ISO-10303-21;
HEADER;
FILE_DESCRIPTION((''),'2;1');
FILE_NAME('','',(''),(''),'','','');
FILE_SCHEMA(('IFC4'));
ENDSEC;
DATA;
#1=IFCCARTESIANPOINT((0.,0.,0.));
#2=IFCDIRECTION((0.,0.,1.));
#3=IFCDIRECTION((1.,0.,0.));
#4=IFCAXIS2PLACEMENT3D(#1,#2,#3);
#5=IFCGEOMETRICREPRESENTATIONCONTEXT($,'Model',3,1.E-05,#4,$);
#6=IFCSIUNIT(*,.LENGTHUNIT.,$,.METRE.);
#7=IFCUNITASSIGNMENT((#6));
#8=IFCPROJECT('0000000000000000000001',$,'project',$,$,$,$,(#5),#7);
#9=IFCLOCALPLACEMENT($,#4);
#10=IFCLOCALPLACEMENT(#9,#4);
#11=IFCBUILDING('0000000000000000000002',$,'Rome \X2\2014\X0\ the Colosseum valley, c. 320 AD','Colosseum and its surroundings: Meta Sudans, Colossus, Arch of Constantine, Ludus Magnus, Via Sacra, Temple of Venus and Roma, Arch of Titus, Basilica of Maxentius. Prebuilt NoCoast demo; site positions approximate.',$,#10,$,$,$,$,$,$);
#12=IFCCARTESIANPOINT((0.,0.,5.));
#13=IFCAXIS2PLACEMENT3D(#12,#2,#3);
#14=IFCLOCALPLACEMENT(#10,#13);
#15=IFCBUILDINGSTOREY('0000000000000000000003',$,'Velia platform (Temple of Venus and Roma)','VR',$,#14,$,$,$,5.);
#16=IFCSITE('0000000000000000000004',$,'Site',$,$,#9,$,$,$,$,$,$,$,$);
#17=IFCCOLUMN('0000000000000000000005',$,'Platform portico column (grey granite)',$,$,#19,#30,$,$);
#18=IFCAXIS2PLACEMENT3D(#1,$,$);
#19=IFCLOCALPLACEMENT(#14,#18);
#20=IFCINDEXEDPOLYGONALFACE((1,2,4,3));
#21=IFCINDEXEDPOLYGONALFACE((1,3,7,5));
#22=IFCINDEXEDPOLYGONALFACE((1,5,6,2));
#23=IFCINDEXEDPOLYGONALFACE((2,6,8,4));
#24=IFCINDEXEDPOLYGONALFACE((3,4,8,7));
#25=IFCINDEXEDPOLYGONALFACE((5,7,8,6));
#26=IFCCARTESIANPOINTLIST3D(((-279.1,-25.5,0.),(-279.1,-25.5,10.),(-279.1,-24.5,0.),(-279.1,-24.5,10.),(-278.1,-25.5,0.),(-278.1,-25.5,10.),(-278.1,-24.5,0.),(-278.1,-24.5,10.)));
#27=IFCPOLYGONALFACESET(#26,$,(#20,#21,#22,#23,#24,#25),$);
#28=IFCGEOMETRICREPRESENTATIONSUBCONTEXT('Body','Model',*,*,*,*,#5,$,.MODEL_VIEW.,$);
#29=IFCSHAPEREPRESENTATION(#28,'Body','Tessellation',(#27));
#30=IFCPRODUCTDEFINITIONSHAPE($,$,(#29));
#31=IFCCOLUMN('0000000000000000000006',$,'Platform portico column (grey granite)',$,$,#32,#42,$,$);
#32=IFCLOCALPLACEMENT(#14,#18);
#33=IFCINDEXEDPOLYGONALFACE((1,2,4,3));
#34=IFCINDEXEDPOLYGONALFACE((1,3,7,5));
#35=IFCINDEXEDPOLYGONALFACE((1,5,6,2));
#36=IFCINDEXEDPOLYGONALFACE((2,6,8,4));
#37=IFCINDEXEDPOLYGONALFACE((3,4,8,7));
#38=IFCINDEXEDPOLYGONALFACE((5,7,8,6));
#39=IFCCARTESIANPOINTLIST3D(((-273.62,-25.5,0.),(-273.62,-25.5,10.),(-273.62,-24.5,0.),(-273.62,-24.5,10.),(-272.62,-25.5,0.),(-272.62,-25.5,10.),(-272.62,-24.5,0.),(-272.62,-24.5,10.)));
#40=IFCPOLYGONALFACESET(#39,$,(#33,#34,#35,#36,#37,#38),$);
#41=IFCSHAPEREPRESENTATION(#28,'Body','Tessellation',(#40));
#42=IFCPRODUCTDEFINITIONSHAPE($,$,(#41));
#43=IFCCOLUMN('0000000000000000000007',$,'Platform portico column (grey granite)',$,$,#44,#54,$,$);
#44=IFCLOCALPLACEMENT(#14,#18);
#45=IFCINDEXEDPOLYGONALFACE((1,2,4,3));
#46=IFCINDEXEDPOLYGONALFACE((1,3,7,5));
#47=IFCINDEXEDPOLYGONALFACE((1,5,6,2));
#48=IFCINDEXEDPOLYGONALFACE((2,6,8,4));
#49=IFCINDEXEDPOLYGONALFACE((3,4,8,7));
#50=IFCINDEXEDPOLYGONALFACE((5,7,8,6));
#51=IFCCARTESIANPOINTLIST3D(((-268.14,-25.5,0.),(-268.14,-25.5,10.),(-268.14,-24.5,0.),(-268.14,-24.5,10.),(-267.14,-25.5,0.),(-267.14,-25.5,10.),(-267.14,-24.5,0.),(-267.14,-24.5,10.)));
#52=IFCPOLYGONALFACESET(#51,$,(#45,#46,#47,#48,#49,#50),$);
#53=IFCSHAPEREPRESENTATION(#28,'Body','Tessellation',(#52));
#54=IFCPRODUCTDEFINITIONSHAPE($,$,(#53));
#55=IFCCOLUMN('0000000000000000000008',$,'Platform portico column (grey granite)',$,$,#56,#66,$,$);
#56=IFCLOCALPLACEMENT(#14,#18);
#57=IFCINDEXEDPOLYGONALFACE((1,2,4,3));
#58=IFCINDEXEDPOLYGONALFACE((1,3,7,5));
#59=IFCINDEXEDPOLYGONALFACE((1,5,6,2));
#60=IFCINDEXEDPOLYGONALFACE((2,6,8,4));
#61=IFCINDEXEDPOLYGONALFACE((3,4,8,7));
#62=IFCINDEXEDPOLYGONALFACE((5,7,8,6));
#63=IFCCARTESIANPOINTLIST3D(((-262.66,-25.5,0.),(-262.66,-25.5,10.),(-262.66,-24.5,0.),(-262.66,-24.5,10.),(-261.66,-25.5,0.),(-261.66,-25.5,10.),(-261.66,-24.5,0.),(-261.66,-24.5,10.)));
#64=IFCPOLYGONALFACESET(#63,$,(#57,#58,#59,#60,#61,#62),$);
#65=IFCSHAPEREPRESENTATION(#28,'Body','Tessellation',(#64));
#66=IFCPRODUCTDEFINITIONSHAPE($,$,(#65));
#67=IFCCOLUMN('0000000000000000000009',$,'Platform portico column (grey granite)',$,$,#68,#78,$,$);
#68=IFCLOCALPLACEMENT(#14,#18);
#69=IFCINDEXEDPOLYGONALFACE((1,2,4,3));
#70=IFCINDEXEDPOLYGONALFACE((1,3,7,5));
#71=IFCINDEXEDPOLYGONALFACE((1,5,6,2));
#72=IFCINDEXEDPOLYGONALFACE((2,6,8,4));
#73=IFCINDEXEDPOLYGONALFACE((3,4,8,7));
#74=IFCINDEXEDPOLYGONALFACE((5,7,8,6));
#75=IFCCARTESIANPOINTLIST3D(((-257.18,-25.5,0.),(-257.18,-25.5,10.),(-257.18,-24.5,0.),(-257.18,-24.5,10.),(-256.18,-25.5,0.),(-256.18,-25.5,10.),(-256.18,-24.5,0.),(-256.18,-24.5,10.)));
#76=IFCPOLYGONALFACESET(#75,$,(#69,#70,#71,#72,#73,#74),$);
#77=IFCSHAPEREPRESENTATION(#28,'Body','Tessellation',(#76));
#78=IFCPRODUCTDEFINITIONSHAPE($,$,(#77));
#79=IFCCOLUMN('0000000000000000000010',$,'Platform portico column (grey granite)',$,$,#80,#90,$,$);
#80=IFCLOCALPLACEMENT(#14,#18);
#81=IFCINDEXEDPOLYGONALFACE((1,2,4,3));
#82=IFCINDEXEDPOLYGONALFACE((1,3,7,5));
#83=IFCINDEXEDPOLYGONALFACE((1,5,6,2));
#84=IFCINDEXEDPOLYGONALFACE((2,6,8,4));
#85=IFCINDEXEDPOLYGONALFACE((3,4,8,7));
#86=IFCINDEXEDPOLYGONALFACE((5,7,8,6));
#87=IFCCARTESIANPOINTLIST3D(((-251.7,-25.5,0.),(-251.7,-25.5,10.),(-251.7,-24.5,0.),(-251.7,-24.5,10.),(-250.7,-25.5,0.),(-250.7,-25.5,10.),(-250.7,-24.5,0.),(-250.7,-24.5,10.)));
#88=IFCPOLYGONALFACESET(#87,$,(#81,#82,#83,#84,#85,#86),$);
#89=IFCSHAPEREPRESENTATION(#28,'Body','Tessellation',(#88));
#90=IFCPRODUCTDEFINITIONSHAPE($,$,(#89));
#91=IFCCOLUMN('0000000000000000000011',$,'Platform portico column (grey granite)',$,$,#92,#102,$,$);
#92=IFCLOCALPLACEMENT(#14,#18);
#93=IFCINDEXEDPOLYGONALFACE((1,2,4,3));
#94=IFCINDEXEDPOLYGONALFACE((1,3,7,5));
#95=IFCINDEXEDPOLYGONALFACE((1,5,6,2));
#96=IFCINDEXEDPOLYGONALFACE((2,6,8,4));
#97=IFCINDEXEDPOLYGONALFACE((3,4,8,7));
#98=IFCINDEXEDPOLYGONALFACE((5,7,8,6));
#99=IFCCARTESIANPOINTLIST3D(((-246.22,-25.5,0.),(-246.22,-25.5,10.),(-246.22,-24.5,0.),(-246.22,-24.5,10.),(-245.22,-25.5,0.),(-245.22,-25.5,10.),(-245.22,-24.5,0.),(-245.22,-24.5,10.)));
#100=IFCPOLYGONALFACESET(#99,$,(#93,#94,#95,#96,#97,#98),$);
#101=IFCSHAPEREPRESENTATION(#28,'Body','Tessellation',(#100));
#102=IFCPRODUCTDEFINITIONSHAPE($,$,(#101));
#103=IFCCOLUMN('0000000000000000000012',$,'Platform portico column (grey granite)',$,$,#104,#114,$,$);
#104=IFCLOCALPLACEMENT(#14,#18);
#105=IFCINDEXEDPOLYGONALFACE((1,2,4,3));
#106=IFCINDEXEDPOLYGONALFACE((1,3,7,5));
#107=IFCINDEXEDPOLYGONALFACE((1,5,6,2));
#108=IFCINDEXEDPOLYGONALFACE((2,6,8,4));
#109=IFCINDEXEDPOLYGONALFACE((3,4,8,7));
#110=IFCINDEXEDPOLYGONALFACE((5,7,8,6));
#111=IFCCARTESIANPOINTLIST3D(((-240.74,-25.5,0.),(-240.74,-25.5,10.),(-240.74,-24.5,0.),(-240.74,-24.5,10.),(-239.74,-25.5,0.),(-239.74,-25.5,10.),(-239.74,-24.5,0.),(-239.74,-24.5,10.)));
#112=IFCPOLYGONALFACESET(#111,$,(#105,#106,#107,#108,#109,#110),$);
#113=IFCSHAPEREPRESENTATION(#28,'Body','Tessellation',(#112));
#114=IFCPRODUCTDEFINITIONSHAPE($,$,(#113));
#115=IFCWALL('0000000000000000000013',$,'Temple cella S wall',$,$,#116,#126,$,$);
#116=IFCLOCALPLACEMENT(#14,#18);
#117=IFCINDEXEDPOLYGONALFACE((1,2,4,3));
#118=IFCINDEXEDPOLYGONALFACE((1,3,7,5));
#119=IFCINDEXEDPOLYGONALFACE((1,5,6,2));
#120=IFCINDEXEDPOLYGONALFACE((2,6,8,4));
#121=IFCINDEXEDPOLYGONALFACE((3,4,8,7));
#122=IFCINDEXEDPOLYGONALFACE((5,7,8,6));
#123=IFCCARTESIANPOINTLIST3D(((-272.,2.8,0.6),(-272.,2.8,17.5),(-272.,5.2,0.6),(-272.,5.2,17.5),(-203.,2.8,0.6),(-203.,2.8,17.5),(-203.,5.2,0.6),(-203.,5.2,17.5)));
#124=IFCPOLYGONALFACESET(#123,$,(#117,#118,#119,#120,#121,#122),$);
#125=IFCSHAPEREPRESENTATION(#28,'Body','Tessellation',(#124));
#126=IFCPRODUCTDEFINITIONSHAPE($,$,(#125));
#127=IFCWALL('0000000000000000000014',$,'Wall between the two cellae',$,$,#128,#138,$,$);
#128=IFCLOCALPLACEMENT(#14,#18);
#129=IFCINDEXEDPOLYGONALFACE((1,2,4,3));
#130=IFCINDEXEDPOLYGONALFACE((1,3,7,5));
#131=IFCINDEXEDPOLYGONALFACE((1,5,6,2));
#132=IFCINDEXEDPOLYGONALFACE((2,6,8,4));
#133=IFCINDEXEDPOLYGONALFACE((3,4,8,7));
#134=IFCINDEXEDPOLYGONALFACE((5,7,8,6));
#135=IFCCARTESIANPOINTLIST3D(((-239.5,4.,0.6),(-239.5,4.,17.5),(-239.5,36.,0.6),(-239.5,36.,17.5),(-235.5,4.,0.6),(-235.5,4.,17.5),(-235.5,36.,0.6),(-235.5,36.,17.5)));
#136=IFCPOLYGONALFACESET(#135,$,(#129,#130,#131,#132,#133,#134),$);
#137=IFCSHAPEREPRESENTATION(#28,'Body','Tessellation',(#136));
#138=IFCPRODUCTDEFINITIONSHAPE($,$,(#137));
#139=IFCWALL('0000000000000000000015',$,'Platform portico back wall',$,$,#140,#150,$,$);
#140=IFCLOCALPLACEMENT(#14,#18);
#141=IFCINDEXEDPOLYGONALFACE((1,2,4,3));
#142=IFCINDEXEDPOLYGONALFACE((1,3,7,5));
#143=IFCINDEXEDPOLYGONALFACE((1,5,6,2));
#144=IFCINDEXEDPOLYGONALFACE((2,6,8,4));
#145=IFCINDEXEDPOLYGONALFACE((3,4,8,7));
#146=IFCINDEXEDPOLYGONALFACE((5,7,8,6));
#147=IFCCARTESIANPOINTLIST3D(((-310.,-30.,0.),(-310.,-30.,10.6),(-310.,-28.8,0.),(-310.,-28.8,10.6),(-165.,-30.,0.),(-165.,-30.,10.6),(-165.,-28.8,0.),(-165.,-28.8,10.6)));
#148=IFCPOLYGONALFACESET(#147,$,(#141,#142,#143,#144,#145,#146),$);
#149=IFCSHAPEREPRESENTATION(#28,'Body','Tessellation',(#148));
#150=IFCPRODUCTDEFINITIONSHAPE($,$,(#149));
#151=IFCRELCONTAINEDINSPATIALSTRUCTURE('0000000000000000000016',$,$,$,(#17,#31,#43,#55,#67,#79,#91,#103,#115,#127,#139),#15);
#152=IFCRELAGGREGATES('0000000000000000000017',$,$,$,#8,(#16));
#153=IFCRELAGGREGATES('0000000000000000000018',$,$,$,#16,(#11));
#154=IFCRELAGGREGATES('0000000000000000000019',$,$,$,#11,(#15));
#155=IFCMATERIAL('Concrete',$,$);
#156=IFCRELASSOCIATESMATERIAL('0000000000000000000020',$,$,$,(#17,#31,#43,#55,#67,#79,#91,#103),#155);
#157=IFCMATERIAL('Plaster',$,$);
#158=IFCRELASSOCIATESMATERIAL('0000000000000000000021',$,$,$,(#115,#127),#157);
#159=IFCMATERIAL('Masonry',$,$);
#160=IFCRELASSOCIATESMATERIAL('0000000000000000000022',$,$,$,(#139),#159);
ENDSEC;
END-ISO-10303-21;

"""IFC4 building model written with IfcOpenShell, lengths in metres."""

from ifc_helpers import new_model, si_unit, frame, origin_with_axes, place, context, subcontext, project, spatial, indexed_curve, outline, extrude, material, element, save


model = new_model("IFC4")

# Units and contexts
model_context = context("Model", 3, precision=1e-05, world=origin_with_axes())
body_context = subcontext(model_context, "Body", "Model", "MODEL_VIEW")
ifc_project = project(units=[si_unit("LENGTHUNIT", "METRE")], contexts=[model_context])

# Site, building, storey
site_placement = place(None, origin_with_axes())
site = spatial("IfcSite", under=ifc_project, at=site_placement, Name="Site")
building_placement = place(site_placement, origin_with_axes())
building = spatial("IfcBuilding", under=site, at=building_placement, Name="Rome — the Colosseum valley, c. 320 AD", Description="Colosseum and its surroundings: Meta Sudans, Colossus, Arch of Constantine, Ludus Magnus, Via Sacra, Temple of Venus and Roma, Arch of Titus, Basilica of Maxentius. Prebuilt NoCoast demo; site positions approximate.")
storey_placement = place(building_placement, frame((0.0, 0.0, 5.0), z_axis=(0.0, 0.0, 1.0), x_axis=(1.0, 0.0, 0.0)))
storey = spatial("IfcBuildingStorey", under=building, at=storey_placement, Name="Velia platform (Temple of Venus and Roma)", Description="VR", Elevation=5.0)

# Columns
ifc_material_1 = material(Name="Concrete")
for number, where, z_axis, x_axis, name in (
    (1, (-279.1, -25.0, 0.0), (0.0, 0.0, 1.0), (1.0, 0.0, 0.0), "Platform portico column (grey granite)"),
    (2, (-273.62, -25.0, 0.0), (0.0, 0.0, 1.0), (1.0, 0.0, 0.0), "Platform portico column (grey granite)"),
    (3, (-268.14, -25.0, 0.0), (0.0, 0.0, 1.0), (1.0, 0.0, 0.0), "Platform portico column (grey granite)"),
    (4, (-262.66, -25.0, 0.0), (0.0, 0.0, 1.0), (1.0, 0.0, 0.0), "Platform portico column (grey granite)"),
    (5, (-257.18, -25.0, 0.0), (0.0, 0.0, 1.0), (1.0, 0.0, 0.0), "Platform portico column (grey granite)"),
    (6, (-251.7, -25.0, 0.0), (0.0, 0.0, 1.0), (1.0, 0.0, 0.0), "Platform portico column (grey granite)"),
    (7, (-246.22, -25.0, 0.0), (0.0, 0.0, 1.0), (1.0, 0.0, 0.0), "Platform portico column (grey granite)"),
    (8, (-240.74, -25.0, 0.0), (0.0, 0.0, 1.0), (1.0, 0.0, 0.0), "Platform portico column (grey granite)"),
):
    element("IfcColumn", number, at=place(storey_placement, frame(where, z_axis=z_axis, x_axis=x_axis)), inside=storey, material=ifc_material_1, Name=name, context=body_context, shape_type="SweptSolid", body=[
        extrude(outline(indexed_curve([(0.0, 0.0), (0.0, 1.0), (1.0, 1.0), (1.0, 0.0), (0.0, 0.0)], self_intersect=False)), frame((0.0, -0.5, 0.0), z_axis=(0.0, 0.0, 1.0), x_axis=(1.0, 0.0, 0.0)), (0.0, 0.0, 1.0), 10.0),
    ])

# Walls
ifc_material_2 = material(Name="Plaster")
wall_1_placement = place(storey_placement, frame((-272.0, 4.0, 0.6), z_axis=(0.0, 0.0, 1.0), x_axis=(1.0, 0.0, 0.0)))
element("IfcWall", 9, at=wall_1_placement, inside=storey, material=ifc_material_2, Name="Temple cella S wall", context=body_context, shape_type="SweptSolid", body=[
    extrude(outline(indexed_curve([(0.0, 0.0), (0.0, 2.4), (69.0, 2.4), (69.0, 0.0), (0.0, 0.0)], self_intersect=False)), frame((0.0, -1.2, 0.0), z_axis=(0.0, 0.0, 1.0), x_axis=(1.0, 0.0, 0.0)), (0.0, 0.0, 1.0), 16.9),
])
wall_2_placement = place(storey_placement, frame((-237.5, 4.0, 0.6), z_axis=(0.0, 0.0, 1.0), x_axis=(0.0, 1.0, 0.0)))
element("IfcWall", 10, at=wall_2_placement, inside=storey, material=ifc_material_2, Name="Wall between the two cellae", context=body_context, shape_type="SweptSolid", body=[
    extrude(outline(indexed_curve([(0.0, 0.0), (0.0, 4.0), (32.0, 4.0), (32.0, 0.0), (0.0, 0.0)], self_intersect=False)), frame((0.0, -2.0, 0.0), z_axis=(0.0, 0.0, 1.0), x_axis=(1.0, 0.0, 0.0)), (0.0, 0.0, 1.0), 16.9),
])
ifc_material_3 = material(Name="Masonry")
wall_3_placement = place(storey_placement, frame((-310.0, -29.4, 0.0), z_axis=(0.0, 0.0, 1.0), x_axis=(1.0, 0.0, 0.0)))
element("IfcWall", 11, at=wall_3_placement, inside=storey, material=ifc_material_3, Name="Platform portico back wall", context=body_context, shape_type="SweptSolid", body=[
    extrude(outline(indexed_curve([(0.0, 0.0), (0.0, 1.2), (145.0, 1.2), (145.0, 0.0), (0.0, 0.0)], self_intersect=False)), frame((0.0, -0.6, 0.0), z_axis=(0.0, 0.0, 1.0), x_axis=(1.0, 0.0, 0.0)), (0.0, 0.0, 1.0), 10.6),
])

save(model, "model.ifc")
